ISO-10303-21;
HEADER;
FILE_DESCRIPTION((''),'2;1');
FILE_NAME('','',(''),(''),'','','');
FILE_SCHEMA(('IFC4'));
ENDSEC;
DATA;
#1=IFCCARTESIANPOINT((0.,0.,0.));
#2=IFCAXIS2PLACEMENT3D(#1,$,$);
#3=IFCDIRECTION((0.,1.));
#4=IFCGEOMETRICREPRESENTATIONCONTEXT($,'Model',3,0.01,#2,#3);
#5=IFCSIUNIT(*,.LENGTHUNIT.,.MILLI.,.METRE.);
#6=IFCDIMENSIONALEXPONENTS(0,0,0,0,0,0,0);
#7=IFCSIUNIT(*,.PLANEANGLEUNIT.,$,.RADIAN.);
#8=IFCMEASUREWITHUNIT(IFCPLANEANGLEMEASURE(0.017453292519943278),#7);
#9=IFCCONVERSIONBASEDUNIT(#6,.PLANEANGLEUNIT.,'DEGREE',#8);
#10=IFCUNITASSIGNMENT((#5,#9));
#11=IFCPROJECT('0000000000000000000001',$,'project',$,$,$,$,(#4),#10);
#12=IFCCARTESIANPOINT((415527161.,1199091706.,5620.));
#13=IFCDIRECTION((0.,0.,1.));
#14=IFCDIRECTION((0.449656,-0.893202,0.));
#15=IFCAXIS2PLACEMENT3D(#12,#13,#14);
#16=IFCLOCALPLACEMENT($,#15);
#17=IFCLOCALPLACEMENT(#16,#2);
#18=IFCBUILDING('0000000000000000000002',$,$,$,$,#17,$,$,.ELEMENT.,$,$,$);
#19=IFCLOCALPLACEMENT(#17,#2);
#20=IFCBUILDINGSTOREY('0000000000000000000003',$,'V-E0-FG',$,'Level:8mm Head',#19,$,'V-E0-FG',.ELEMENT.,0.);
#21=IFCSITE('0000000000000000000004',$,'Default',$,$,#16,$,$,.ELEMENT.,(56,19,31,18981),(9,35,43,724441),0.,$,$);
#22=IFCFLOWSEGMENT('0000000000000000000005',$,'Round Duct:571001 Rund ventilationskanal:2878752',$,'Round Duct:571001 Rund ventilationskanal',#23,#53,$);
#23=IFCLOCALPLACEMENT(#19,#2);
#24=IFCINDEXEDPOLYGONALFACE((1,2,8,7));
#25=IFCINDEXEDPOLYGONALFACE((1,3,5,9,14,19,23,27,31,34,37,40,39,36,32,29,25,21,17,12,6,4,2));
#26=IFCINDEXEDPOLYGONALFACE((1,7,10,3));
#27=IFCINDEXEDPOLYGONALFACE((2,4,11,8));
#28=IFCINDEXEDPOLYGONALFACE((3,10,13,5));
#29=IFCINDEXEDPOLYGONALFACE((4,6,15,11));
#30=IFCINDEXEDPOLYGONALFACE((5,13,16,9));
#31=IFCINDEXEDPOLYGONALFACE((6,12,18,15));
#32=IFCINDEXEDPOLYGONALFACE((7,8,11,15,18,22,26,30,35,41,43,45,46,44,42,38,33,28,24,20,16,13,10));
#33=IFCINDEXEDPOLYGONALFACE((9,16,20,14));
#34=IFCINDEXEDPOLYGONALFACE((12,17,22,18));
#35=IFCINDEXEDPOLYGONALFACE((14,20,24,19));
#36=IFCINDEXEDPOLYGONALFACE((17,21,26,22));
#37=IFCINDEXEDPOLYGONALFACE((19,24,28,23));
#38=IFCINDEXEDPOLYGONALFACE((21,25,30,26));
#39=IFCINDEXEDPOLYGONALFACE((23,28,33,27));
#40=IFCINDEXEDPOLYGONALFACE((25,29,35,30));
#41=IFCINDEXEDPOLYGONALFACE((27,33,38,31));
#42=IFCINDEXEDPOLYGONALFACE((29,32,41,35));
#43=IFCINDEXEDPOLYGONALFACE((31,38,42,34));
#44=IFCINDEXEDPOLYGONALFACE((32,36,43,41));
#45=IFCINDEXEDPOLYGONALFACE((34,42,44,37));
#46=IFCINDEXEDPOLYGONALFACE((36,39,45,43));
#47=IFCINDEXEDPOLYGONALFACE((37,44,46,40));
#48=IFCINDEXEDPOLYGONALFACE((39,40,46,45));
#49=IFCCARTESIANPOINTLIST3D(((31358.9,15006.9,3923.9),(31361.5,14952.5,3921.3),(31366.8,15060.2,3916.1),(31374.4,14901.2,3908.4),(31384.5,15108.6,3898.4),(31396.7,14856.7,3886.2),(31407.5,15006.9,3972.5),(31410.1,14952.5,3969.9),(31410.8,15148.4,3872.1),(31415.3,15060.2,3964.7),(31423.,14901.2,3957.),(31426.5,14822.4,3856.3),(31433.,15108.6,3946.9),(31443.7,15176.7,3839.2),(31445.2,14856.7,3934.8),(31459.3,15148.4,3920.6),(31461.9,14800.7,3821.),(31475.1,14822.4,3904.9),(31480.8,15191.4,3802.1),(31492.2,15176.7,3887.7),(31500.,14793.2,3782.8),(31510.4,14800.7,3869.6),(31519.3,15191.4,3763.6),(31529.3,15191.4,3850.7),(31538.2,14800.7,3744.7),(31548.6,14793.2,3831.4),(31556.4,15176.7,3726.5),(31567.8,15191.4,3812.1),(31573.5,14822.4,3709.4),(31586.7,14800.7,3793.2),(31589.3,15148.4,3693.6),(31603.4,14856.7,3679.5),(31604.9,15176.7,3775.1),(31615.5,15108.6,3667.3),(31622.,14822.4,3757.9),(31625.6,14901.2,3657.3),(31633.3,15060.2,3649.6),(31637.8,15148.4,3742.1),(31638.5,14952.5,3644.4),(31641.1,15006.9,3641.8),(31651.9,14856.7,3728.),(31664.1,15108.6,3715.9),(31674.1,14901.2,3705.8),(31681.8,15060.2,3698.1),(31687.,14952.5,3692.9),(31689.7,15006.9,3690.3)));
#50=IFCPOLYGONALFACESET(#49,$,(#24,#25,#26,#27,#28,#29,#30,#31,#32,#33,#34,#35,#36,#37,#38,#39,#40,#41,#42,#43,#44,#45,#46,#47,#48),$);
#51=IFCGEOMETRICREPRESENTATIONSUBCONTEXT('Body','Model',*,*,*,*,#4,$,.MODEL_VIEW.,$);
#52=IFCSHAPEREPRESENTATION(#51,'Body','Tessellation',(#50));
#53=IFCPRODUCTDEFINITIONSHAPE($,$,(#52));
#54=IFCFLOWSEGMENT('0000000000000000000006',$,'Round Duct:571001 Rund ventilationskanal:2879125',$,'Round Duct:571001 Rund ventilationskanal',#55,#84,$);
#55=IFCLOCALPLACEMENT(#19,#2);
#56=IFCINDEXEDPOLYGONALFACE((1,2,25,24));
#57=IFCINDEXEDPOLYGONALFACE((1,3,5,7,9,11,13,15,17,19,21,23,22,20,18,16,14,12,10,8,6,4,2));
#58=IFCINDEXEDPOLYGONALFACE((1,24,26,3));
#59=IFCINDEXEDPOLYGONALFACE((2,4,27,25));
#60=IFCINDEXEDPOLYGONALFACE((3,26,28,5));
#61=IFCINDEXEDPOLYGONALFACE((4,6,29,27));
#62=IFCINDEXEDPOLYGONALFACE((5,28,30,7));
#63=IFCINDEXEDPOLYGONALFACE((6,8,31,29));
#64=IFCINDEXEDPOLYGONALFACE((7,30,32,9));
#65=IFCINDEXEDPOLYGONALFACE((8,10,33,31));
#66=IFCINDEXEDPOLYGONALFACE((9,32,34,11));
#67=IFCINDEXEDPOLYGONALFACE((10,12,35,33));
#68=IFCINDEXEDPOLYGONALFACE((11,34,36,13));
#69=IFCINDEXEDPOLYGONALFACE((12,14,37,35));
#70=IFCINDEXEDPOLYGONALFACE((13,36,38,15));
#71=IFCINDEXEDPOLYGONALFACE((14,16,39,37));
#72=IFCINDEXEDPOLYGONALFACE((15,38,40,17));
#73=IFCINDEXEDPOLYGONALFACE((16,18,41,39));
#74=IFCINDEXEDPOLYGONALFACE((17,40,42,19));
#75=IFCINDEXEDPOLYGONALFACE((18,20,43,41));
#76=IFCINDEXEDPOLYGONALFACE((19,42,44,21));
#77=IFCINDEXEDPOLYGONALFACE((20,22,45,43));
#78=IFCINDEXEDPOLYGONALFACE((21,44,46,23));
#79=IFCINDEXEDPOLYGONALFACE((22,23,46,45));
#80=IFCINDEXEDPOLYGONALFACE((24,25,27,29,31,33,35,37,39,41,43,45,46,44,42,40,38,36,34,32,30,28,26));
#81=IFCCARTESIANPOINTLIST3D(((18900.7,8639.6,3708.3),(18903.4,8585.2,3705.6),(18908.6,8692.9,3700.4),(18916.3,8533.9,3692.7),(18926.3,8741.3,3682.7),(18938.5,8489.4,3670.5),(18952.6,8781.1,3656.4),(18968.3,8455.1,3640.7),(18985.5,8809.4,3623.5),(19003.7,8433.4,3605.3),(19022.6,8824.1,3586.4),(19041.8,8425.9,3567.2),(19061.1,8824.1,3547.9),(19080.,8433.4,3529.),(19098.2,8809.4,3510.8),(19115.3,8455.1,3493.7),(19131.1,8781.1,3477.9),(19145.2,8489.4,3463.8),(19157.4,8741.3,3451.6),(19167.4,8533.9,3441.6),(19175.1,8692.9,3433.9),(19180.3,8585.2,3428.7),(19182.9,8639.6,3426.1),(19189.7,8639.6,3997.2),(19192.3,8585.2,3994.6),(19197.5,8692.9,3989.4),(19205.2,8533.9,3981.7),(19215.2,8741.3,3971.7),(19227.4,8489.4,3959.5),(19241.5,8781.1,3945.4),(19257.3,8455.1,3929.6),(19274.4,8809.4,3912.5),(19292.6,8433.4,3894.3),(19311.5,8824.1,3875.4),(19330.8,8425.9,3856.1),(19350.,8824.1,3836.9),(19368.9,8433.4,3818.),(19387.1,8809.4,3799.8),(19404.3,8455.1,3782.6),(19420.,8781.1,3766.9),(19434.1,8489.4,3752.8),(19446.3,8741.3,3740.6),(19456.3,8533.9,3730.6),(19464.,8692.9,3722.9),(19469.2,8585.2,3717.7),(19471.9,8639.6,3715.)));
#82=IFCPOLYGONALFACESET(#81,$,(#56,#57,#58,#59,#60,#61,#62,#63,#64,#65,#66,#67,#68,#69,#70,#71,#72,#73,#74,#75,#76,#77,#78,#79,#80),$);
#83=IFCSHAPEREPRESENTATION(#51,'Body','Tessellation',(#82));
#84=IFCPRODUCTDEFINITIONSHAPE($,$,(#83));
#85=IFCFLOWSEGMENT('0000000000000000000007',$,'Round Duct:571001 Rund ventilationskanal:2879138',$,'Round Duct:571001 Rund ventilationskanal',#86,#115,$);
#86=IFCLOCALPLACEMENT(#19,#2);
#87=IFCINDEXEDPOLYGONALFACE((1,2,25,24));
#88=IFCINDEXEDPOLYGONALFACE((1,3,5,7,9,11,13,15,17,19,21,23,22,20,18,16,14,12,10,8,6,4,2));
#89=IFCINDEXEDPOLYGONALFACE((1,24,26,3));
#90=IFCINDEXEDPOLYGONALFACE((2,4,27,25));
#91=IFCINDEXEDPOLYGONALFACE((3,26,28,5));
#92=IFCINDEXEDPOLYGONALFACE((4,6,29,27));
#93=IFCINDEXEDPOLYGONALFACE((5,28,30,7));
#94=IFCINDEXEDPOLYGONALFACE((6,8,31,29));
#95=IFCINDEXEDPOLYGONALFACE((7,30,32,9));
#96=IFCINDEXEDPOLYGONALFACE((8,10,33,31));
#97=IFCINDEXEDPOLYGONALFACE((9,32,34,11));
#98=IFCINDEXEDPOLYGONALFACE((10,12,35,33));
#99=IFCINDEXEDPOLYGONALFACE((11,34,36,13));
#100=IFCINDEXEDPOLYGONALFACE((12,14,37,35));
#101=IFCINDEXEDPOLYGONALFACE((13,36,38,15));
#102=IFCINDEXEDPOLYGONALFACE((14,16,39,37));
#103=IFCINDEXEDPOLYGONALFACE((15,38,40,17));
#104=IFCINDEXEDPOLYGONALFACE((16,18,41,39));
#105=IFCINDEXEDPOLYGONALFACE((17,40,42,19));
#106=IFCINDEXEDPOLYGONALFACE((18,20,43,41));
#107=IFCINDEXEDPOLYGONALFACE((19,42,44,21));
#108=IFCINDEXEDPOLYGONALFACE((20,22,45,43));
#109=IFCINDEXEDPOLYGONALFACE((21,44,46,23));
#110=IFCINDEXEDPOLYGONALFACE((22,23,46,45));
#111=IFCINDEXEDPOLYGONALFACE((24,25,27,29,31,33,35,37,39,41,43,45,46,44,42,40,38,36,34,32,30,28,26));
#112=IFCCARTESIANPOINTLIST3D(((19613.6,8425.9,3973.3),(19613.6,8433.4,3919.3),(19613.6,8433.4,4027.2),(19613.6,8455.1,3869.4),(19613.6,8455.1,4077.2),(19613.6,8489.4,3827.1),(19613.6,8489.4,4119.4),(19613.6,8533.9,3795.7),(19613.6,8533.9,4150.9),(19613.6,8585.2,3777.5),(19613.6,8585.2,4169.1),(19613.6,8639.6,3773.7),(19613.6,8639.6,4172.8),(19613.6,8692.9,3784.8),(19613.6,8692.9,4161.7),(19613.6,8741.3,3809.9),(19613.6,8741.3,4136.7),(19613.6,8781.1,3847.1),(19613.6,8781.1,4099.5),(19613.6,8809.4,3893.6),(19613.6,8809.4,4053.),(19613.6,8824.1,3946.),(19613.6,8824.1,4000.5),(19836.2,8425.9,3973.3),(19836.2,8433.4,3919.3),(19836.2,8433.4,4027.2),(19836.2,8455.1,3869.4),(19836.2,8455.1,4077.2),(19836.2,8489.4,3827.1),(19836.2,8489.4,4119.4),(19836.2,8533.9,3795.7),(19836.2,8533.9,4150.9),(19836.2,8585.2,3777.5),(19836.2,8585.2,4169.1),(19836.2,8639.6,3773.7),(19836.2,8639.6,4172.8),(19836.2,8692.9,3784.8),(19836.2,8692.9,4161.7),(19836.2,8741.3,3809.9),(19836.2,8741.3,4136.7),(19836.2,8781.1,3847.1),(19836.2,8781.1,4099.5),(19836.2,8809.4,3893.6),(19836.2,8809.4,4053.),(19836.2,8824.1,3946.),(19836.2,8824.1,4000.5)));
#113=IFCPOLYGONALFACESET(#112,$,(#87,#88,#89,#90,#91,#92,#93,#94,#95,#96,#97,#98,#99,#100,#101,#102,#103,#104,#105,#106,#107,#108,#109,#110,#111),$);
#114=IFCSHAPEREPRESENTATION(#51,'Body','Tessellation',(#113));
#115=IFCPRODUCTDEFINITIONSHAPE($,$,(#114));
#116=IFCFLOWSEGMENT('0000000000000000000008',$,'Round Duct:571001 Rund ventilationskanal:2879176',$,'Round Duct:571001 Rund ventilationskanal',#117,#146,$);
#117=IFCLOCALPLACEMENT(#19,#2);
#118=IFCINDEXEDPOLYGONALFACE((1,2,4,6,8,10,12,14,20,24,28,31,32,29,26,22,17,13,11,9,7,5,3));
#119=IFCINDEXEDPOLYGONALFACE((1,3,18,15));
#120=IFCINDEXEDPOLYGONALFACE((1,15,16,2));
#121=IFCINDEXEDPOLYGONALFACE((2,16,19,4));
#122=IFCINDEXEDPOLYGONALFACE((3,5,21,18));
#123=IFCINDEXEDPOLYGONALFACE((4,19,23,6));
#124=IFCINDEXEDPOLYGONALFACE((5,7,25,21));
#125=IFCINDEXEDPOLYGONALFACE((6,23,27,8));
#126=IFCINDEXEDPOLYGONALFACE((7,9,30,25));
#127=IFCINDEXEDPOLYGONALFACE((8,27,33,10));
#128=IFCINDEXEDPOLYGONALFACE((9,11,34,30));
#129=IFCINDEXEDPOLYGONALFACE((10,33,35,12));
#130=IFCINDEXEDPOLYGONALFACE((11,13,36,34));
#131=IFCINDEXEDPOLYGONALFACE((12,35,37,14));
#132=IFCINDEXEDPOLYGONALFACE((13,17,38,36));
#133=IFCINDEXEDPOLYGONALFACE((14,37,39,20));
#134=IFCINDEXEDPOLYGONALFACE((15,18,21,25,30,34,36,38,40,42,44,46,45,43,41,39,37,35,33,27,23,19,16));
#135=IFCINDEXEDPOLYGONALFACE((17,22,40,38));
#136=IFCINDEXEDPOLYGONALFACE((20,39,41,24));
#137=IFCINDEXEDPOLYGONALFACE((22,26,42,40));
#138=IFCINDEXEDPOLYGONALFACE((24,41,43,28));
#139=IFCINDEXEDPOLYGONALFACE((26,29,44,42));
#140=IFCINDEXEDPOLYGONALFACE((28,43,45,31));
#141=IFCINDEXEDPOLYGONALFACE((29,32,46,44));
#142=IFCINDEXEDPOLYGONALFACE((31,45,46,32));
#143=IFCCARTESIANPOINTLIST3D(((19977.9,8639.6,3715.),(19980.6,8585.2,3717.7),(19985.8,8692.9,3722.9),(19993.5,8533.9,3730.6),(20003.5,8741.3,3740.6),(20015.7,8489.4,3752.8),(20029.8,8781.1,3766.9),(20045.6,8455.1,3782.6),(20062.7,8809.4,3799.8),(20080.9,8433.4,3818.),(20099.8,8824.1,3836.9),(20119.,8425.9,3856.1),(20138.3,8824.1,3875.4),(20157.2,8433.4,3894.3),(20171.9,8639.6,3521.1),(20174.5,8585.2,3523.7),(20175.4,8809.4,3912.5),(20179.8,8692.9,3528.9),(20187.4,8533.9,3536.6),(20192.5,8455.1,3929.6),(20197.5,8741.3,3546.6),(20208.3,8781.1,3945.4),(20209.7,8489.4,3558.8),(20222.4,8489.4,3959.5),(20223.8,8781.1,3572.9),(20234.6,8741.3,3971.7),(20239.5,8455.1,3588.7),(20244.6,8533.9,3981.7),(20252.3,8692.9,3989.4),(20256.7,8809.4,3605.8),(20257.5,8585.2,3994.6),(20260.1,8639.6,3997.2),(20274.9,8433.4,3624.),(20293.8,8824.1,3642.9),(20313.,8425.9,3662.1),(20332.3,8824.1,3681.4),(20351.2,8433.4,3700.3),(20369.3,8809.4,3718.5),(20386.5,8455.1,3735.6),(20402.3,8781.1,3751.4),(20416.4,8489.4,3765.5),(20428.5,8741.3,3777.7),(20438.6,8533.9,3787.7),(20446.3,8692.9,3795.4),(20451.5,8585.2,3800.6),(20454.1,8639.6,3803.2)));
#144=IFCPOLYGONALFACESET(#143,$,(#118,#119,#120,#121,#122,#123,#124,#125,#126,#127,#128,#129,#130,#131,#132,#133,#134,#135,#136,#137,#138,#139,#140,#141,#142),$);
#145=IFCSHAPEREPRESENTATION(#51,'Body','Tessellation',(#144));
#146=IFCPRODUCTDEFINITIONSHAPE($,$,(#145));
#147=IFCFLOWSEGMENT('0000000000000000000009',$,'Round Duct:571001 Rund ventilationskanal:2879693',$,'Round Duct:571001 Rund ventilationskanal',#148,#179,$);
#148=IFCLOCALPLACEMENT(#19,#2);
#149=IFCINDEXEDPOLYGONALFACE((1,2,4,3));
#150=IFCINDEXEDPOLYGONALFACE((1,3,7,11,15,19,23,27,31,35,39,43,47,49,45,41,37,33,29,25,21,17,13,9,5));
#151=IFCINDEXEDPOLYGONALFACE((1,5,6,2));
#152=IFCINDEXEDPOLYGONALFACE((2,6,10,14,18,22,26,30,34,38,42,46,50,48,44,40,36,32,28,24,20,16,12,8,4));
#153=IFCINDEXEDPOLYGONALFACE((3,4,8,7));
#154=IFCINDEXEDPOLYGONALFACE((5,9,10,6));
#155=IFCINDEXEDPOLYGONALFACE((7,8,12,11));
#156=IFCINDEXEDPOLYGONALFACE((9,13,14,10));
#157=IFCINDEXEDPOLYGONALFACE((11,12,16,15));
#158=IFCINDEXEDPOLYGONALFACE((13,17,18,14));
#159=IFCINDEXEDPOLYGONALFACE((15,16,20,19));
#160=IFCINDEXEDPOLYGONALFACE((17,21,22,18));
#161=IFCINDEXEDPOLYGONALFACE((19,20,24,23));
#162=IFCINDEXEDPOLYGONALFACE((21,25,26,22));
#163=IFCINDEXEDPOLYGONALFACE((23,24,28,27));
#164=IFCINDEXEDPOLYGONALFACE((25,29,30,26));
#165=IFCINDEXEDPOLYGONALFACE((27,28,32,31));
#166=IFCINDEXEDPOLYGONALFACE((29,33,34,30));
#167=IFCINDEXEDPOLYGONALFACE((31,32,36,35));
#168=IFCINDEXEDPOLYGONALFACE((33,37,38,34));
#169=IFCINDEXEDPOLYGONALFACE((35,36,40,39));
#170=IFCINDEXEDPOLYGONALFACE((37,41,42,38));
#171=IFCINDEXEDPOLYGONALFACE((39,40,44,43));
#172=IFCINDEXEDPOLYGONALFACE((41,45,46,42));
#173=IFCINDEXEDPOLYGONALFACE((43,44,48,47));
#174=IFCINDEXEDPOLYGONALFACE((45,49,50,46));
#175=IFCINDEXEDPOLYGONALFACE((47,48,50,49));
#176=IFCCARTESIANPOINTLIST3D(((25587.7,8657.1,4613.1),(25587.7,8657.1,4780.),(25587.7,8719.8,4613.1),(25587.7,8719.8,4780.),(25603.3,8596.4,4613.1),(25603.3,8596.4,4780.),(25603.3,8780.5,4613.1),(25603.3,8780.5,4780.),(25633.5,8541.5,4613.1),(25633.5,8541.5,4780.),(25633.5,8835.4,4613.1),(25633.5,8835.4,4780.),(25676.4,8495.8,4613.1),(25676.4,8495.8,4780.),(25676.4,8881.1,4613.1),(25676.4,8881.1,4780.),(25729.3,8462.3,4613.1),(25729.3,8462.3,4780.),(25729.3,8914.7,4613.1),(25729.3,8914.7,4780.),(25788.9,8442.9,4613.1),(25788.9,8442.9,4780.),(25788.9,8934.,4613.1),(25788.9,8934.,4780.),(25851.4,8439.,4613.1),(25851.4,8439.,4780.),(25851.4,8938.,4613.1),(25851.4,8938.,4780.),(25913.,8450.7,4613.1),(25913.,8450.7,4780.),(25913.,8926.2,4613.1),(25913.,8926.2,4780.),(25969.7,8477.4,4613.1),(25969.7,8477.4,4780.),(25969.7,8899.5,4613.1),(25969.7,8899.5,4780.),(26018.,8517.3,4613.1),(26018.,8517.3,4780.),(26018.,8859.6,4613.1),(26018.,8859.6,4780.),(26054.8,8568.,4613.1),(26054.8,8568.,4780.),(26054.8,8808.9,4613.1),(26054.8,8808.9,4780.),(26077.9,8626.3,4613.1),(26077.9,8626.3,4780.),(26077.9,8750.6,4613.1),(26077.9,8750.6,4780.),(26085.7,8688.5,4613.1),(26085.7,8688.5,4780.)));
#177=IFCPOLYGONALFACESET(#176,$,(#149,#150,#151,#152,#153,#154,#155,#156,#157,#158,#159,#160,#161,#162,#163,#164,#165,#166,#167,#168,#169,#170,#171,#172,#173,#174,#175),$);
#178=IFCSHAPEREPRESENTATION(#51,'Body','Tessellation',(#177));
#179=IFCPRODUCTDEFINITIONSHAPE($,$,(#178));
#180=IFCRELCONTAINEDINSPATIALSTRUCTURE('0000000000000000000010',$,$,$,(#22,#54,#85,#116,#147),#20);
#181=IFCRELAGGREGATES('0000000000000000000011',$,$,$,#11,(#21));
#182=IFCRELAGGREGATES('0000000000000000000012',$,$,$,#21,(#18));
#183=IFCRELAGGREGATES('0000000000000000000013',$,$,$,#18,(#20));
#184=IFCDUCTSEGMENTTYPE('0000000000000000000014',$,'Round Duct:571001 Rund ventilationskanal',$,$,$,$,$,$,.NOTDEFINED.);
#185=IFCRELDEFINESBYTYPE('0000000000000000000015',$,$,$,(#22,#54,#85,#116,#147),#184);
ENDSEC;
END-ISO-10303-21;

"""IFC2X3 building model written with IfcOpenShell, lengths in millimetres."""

from ifc_helpers import new_model, entity, si_unit, converted_unit, direction, frame, frame_2d, origin, place, context, subcontext, project, spatial, circle, extrude, type_object, element, save


model = new_model("IFC2X3")

# Units and contexts
model_context = context("Model", 3, precision=0.01, world=origin(), true_north=direction((0.0, 1.0)))
body_context = subcontext(model_context, "Body", "Model", "MODEL_VIEW")
ifc_project = project(units=[si_unit("LENGTHUNIT", "METRE", prefix="MILLI"), converted_unit("PLANEANGLEUNIT", "DEGREE", entity("IfcPlaneAngleMeasure", 0.017453292519943278), si_unit("PLANEANGLEUNIT", "RADIAN"), dimensions=[0, 0, 0, 0, 0, 0, 0])], contexts=[model_context])

# Site, building, storey
site_placement = place(None, frame((415527161.0, 1199091706.0, 5620.0), z_axis=(0.0, 0.0, 1.0), x_axis=(0.449656, -0.893202, 0.0)))
site = spatial("IfcSite", under=ifc_project, at=site_placement, Name="Default", CompositionType="ELEMENT", RefLatitude=(56, 19, 31, 18981), RefLongitude=(9, 35, 43, 724441), RefElevation=0.0)
building_placement = place(site_placement, origin())
building = spatial("IfcBuilding", under=site, at=building_placement, CompositionType="ELEMENT")
storey_placement = place(building_placement, origin())
storey = spatial("IfcBuildingStorey", under=building, at=storey_placement, Name="V-E0-FG", ObjectType="Level:8mm Head", LongName="V-E0-FG", CompositionType="ELEMENT", Elevation=0.0)

# Flow segments
duct_segment_type = type_object("IfcDuctSegmentType", Name="Round Duct:571001 Rund ventilationskanal", PredefinedType="NOTDEFINED")
flow_segment_1_placement = place(storey_placement, origin())
element("IfcFlowSegment", 1, at=flow_segment_1_placement, inside=storey, type_object=duct_segment_type, Name="Round Duct:571001 Rund ventilationskanal:2878752", ObjectType="Round Duct:571001 Rund ventilationskanal", context=body_context, shape_type="SweptSolid", body=[
    extrude(circle(Radius=200.0, at=frame_2d((0.0, 0.0), x_axis=(1.0, 0.0))), frame((31500.0, 14993.2, 3782.8), z_axis=(0.707107, 0.0, 0.707107), x_axis=(0.0, -1.0, 0.0)), (0.0, 0.0, 1.0), 68.7),
])
flow_segment_2_placement = place(storey_placement, origin())
element("IfcFlowSegment", 2, at=flow_segment_2_placement, inside=storey, type_object=duct_segment_type, Name="Round Duct:571001 Rund ventilationskanal:2879125", ObjectType="Round Duct:571001 Rund ventilationskanal", context=body_context, shape_type="SweptSolid", body=[
    extrude(circle(Radius=200.0, at=frame_2d((0.0, 0.0), x_axis=(1.0, 0.0))), frame((19041.8, 8625.9, 3567.2), z_axis=(0.707107, 0.0, 0.707107), x_axis=(0.0, -1.0, 0.0)), (0.0, 0.0, 1.0), 408.6),
])
flow_segment_3_placement = place(storey_placement, origin())
element("IfcFlowSegment", 3, at=flow_segment_3_placement, inside=storey, type_object=duct_segment_type, Name="Round Duct:571001 Rund ventilationskanal:2879138", ObjectType="Round Duct:571001 Rund ventilationskanal", context=body_context, shape_type="SweptSolid", body=[
    extrude(circle(Radius=200.0, at=frame_2d((0.0, 0.0), x_axis=(1.0, 0.0))), frame((19613.6, 8625.9, 3973.3), z_axis=(1.0, 0.0, 0.0), x_axis=(0.0, -1.0, 0.0)), (0.0, 0.0, 1.0), 222.6),
])
flow_segment_4_placement = place(storey_placement, origin())
element("IfcFlowSegment", 4, at=flow_segment_4_placement, inside=storey, type_object=duct_segment_type, Name="Round Duct:571001 Rund ventilationskanal:2879176", ObjectType="Round Duct:571001 Rund ventilationskanal", context=body_context, shape_type="SweptSolid", body=[
    extrude(circle(Radius=200.0, at=frame_2d((0.0, 0.0), x_axis=(1.0, 0.0))), frame((20119.0, 8625.9, 3856.1), z_axis=(0.707107, 0.0, -0.707107), x_axis=(0.0, -1.0, 0.0)), (0.0, 0.0, 1.0), 274.3),
])
flow_segment_5_placement = place(storey_placement, origin())
element("IfcFlowSegment", 5, at=flow_segment_5_placement, inside=storey, type_object=duct_segment_type, Name="Round Duct:571001 Rund ventilationskanal:2879693", ObjectType="Round Duct:571001 Rund ventilationskanal", context=body_context, shape_type="SweptSolid", body=[
    extrude(circle(Radius=250.0, at=frame_2d((0.0, 0.0), x_axis=(1.0, 0.0))), frame((25835.7, 8688.5, 4613.1)), (0.0, 0.0, 1.0), 166.9),
])

save(model, "model.ifc")
